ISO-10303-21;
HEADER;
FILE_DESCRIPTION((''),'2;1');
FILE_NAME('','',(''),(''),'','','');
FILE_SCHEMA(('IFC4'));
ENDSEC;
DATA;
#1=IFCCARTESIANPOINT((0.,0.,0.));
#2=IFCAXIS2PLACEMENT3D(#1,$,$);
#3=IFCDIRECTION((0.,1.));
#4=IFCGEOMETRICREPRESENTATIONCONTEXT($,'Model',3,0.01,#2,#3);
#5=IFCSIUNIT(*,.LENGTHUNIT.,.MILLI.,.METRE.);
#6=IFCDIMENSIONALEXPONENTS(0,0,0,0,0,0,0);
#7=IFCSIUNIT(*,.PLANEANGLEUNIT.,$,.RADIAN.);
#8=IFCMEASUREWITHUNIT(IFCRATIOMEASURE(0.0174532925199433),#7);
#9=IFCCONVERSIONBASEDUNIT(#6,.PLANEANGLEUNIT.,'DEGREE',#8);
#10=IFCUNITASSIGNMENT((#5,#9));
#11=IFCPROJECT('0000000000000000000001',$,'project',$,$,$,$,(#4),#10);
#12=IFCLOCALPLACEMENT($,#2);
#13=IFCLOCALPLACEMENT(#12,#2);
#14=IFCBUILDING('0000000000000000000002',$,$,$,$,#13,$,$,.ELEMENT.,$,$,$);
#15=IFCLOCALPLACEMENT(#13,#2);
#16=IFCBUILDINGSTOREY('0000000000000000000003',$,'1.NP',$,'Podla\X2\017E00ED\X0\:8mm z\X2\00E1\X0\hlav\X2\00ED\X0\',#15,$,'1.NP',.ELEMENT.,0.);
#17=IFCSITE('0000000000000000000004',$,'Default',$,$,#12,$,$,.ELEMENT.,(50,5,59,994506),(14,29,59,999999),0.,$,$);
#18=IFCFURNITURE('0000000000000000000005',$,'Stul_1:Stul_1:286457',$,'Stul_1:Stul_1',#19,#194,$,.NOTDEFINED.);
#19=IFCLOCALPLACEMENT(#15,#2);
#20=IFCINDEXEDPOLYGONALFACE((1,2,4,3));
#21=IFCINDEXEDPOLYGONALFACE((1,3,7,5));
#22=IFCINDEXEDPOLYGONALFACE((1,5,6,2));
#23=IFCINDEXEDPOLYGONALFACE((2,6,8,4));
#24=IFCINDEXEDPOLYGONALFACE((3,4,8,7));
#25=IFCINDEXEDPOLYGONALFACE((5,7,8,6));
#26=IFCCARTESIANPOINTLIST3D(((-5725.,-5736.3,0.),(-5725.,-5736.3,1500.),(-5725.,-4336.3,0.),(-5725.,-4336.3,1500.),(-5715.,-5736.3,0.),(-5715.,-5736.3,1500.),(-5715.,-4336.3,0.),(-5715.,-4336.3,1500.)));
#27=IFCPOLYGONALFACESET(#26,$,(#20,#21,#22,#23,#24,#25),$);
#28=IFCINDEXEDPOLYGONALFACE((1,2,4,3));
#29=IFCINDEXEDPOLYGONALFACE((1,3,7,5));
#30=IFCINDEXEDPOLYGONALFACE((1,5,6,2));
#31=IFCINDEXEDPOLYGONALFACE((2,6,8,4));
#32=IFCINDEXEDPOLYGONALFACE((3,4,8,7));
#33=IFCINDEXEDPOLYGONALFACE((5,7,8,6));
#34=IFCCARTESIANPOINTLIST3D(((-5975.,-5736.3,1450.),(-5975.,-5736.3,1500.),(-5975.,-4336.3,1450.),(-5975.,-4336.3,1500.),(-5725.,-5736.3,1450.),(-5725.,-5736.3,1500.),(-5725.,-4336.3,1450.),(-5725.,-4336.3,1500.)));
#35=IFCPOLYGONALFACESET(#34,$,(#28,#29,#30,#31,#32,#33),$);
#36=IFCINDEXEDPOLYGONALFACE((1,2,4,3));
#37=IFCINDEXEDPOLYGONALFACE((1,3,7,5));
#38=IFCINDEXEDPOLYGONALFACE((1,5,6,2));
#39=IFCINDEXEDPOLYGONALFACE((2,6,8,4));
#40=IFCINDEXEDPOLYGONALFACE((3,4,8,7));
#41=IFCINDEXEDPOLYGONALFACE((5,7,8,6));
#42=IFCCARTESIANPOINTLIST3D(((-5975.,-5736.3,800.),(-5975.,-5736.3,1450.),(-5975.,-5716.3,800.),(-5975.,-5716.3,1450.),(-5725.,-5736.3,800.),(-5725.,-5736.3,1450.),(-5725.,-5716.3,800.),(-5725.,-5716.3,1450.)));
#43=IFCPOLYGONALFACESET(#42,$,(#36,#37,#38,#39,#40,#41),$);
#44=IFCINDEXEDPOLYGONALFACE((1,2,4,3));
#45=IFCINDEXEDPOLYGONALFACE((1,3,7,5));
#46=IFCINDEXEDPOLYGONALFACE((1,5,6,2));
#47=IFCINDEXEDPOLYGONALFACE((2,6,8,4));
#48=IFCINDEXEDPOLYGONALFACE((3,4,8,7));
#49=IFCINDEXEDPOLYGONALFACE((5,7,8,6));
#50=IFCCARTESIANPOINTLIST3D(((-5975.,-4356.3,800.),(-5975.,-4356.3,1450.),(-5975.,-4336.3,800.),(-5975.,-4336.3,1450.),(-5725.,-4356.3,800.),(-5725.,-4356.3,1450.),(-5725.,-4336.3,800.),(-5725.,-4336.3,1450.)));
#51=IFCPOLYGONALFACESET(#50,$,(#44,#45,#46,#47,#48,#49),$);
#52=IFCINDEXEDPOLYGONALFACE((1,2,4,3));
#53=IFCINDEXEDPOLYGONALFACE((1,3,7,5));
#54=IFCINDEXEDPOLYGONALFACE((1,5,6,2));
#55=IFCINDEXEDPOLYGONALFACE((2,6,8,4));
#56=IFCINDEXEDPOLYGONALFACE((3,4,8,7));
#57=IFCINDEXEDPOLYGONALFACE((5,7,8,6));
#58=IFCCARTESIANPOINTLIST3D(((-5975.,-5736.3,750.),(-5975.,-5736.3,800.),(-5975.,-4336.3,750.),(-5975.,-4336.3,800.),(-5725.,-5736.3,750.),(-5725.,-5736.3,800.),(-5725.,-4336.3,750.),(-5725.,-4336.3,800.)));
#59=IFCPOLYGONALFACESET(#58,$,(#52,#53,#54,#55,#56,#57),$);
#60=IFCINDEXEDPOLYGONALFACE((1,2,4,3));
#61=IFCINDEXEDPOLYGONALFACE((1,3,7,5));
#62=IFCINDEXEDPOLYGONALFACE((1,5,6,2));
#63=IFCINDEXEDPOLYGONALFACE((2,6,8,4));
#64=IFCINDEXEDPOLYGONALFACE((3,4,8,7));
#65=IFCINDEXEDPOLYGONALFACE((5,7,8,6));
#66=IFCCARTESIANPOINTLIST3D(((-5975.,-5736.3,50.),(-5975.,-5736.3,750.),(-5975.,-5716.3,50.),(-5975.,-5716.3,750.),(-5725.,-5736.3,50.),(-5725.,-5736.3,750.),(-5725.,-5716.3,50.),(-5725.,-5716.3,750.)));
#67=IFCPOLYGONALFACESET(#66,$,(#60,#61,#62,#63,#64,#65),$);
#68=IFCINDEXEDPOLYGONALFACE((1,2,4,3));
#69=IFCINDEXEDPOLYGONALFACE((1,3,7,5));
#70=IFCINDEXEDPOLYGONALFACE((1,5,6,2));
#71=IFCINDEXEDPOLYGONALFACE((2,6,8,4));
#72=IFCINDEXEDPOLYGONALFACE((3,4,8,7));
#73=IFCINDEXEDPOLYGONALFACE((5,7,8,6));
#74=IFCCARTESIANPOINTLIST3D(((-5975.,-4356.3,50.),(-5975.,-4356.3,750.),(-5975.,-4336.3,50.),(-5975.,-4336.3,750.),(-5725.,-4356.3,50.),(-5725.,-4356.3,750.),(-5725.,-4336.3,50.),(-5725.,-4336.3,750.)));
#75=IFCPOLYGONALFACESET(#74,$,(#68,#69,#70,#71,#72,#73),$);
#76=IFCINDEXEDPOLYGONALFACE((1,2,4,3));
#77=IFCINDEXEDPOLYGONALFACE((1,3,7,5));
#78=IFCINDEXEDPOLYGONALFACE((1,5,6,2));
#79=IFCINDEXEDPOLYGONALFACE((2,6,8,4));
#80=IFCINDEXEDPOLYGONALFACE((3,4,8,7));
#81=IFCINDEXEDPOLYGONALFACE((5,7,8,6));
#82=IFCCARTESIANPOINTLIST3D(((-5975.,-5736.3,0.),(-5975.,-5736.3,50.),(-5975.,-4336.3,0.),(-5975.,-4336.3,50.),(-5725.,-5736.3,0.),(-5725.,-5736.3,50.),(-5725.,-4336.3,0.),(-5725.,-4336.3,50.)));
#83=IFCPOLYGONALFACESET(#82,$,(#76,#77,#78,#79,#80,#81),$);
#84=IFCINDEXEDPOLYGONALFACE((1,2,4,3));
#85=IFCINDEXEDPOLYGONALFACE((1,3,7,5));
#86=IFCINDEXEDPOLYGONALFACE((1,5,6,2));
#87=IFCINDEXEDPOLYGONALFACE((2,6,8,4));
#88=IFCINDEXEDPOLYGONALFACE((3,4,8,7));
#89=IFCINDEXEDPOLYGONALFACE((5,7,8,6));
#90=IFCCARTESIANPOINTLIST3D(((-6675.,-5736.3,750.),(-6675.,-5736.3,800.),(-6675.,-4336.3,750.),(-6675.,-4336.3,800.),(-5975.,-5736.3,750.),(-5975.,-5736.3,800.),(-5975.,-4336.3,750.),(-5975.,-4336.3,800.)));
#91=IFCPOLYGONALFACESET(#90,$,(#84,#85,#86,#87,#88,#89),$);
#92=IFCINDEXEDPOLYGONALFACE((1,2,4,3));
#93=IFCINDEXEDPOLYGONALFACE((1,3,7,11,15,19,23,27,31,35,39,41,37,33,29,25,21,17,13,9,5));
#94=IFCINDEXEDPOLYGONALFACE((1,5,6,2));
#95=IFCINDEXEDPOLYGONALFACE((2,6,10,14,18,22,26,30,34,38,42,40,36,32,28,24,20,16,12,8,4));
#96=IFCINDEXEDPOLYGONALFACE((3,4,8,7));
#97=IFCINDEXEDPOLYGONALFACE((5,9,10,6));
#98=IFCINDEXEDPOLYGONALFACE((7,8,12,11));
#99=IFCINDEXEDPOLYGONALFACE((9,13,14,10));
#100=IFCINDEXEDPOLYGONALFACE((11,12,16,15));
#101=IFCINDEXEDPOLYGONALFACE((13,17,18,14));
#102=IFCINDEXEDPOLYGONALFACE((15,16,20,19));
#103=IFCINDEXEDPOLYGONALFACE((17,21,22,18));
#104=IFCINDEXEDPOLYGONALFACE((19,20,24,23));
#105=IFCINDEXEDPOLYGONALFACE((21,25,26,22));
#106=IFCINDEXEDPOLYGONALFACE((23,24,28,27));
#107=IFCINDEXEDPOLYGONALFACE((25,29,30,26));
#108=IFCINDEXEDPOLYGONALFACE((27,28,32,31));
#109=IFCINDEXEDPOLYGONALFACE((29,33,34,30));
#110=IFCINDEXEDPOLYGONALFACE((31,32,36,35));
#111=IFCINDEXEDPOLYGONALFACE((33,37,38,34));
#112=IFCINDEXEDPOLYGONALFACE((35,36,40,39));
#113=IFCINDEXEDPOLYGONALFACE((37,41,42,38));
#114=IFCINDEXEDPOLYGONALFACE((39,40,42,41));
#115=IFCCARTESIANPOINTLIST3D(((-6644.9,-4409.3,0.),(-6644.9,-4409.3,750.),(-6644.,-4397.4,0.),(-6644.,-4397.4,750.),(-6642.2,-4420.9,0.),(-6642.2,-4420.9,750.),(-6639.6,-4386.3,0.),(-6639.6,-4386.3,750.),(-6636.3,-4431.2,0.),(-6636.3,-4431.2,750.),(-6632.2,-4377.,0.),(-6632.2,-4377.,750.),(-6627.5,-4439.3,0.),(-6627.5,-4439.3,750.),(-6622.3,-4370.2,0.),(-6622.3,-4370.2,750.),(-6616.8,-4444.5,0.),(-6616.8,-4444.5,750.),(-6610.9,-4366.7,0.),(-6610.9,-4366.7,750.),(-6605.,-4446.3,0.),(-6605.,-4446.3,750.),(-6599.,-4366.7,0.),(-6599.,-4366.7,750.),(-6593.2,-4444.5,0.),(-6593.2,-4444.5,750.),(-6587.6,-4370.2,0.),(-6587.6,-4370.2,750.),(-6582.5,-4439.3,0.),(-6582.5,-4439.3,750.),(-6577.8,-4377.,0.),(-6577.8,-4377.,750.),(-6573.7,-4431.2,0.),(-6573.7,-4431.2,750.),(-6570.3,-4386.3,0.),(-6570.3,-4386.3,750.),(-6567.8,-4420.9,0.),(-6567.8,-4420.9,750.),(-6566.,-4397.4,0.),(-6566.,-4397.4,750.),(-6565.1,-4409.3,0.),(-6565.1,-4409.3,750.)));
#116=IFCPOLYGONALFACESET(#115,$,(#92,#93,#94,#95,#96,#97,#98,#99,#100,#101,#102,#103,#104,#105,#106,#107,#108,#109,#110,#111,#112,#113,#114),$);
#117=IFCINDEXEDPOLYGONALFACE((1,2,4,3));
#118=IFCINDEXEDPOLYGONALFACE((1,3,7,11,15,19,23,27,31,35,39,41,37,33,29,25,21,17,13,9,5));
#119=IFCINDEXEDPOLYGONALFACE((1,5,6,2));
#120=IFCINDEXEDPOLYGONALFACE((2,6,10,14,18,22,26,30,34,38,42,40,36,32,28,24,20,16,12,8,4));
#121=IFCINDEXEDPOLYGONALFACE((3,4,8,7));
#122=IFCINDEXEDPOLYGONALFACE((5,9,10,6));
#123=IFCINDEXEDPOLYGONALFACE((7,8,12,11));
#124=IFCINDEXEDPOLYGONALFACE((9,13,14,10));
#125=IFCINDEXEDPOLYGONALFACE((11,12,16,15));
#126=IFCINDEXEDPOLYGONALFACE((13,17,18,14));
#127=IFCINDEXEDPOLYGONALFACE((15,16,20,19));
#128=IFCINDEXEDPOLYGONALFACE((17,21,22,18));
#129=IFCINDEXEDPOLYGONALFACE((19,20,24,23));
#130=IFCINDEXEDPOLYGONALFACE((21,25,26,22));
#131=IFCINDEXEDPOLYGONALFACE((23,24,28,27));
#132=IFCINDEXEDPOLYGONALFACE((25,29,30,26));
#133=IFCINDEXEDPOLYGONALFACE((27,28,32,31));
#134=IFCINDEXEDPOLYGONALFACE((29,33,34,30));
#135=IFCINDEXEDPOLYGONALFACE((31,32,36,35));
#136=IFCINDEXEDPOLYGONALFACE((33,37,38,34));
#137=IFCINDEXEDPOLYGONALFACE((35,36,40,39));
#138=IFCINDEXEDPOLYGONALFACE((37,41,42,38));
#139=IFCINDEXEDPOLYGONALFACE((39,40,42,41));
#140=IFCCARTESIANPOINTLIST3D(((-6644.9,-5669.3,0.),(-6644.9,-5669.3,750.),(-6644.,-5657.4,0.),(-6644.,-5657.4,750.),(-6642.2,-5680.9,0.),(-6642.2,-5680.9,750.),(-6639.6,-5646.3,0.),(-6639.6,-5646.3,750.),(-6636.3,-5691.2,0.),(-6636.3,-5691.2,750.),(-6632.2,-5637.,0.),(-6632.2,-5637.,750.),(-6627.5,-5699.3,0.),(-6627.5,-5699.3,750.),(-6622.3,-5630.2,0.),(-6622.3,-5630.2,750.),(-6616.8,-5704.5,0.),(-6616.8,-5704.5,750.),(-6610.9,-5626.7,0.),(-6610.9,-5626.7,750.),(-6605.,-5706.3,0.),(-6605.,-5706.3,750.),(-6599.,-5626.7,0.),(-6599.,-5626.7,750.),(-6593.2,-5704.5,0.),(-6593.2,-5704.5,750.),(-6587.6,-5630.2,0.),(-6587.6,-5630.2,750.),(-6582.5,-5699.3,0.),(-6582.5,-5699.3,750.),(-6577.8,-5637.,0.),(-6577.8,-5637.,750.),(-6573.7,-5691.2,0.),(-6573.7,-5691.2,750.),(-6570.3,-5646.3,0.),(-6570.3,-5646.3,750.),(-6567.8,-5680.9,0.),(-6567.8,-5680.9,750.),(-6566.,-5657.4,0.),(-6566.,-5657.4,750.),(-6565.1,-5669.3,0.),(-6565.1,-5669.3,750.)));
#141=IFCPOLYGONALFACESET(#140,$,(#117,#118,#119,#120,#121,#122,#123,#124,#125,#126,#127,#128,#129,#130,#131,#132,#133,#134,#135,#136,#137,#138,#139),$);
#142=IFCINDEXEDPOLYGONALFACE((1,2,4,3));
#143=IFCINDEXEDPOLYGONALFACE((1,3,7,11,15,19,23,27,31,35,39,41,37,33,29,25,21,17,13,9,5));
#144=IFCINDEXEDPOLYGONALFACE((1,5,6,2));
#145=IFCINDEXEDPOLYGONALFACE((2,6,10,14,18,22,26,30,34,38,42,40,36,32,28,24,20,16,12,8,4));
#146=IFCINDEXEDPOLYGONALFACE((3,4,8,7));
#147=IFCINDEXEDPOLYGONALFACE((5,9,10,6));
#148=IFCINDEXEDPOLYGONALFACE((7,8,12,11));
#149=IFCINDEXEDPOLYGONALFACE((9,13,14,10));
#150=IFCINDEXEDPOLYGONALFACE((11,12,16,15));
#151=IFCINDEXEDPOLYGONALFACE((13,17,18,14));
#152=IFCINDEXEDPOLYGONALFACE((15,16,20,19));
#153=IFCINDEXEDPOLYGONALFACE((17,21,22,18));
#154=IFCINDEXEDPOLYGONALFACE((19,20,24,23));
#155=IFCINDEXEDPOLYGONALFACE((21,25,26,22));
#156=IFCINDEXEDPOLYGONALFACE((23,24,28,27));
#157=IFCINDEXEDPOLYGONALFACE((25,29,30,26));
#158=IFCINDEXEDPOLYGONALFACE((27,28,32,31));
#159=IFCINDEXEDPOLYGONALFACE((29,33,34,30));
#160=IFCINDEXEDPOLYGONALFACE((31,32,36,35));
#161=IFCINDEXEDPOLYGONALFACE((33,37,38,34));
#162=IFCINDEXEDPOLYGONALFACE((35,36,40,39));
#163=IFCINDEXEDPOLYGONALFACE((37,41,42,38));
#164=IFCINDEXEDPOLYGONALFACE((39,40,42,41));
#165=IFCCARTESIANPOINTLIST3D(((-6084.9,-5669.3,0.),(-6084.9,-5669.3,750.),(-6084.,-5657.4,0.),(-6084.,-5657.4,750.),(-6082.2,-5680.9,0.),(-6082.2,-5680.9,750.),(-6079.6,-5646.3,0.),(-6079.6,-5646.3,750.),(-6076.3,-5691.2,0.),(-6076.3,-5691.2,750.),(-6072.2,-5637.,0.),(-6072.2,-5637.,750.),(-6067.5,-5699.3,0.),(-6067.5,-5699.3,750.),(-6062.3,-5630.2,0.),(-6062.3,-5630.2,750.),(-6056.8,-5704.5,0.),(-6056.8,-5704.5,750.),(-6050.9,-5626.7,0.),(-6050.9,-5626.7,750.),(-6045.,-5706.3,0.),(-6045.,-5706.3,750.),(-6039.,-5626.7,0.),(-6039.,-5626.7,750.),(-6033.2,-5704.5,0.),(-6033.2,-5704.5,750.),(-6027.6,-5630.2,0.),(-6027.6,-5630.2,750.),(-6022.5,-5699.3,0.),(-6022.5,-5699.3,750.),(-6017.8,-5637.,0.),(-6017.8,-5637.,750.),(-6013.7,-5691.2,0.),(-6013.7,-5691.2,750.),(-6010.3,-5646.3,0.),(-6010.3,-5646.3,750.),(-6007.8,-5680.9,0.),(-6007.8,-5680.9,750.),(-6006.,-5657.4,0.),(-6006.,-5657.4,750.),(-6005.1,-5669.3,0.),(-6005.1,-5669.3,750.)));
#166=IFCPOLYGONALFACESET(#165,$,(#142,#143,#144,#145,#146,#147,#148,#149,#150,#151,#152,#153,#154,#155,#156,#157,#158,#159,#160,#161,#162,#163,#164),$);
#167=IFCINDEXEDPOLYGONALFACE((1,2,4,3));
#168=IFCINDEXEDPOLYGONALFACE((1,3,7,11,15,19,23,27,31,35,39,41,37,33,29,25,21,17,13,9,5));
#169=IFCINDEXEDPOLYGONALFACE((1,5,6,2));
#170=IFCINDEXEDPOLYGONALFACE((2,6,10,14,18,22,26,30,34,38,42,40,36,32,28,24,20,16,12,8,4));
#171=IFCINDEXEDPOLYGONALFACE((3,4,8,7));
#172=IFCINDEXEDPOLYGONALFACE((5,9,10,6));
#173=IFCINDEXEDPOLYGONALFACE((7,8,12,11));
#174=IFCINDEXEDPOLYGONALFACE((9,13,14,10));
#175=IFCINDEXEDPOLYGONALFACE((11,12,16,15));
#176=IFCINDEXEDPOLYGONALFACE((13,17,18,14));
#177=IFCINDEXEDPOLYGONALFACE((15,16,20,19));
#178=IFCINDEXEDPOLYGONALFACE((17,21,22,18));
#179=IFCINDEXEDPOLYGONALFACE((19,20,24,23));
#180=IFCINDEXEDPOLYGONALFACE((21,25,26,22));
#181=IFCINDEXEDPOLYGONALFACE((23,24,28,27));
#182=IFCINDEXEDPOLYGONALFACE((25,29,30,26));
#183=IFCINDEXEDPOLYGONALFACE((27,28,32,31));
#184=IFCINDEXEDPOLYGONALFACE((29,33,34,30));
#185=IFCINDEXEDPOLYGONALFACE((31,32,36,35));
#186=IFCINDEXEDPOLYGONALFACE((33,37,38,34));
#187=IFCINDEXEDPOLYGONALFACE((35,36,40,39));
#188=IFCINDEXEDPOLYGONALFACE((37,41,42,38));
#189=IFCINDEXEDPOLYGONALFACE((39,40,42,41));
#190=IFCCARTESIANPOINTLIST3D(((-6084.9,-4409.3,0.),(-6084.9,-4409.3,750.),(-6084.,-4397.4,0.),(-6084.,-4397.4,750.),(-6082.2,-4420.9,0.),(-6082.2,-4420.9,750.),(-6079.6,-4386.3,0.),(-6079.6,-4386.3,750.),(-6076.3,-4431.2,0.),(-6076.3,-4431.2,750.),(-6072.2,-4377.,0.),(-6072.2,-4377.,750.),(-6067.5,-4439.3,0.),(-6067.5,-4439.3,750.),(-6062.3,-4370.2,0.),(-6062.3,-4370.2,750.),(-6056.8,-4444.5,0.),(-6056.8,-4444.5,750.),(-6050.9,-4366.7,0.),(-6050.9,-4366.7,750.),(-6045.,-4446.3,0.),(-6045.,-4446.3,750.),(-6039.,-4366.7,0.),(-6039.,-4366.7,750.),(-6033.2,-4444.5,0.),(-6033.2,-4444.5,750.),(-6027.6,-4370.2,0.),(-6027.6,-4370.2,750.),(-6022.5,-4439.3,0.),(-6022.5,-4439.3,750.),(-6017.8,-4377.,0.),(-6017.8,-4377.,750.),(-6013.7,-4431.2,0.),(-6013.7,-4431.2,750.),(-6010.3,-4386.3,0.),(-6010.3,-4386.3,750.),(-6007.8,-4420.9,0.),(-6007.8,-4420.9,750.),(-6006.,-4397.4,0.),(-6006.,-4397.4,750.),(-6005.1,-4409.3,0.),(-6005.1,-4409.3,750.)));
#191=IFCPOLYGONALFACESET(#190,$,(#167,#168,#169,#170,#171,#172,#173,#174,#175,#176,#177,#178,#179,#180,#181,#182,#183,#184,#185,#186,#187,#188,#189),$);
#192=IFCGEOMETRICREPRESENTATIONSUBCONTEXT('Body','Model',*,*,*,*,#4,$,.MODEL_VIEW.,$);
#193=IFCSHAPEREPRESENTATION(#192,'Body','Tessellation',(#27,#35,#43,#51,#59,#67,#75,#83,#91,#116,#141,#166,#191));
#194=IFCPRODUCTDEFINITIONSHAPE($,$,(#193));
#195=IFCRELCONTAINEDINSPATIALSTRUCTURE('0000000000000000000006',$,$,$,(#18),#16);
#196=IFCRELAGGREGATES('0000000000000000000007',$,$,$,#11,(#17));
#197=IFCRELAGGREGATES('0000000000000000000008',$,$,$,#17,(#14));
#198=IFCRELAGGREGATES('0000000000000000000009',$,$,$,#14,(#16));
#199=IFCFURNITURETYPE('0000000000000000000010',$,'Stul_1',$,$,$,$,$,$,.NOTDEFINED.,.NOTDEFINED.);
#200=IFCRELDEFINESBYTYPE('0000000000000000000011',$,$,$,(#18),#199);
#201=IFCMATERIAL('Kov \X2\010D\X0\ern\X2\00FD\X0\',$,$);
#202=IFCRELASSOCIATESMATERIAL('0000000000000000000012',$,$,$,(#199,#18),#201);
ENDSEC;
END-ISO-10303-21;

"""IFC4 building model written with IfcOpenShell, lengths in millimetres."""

from ifc_helpers import new_model, entity, si_unit, converted_unit, direction, frame, frame_2d, origin, origin_2d_with_axis, place, context, subcontext, project, spatial, rectangle, circle, extrude, source, transform, mapped, material, type_object, type_shapes, element, save


model = new_model("IFC4")

# Units and contexts
model_context = context("Model", 3, precision=0.01, world=origin(), true_north=direction((0.0, 1.0)))
body_context = subcontext(model_context, "Body", "Model", "MODEL_VIEW")
ifc_project = project(units=[si_unit("LENGTHUNIT", "METRE", prefix="MILLI"), converted_unit("PLANEANGLEUNIT", "DEGREE", entity("IfcRatioMeasure", 0.0174532925199433), si_unit("PLANEANGLEUNIT", "RADIAN"), dimensions=[0, 0, 0, 0, 0, 0, 0])], contexts=[model_context])

# Site, building, storey
site_placement = place(None, origin())
site = spatial("IfcSite", under=ifc_project, at=site_placement, Name="Default", CompositionType="ELEMENT", RefLatitude=(50, 5, 59, 994506), RefLongitude=(14, 29, 59, 999999), RefElevation=0.0)
building_placement = place(site_placement, origin())
building = spatial("IfcBuilding", under=site, at=building_placement, CompositionType="ELEMENT")
storey_placement = place(building_placement, origin())
storey = spatial("IfcBuildingStorey", under=building, at=storey_placement, Name="1.NP", ObjectType="Podlaží:8mm záhlaví", LongName="1.NP", CompositionType="ELEMENT", Elevation=0.0)

# Furniture
ifc_material_1 = material(Name="Kov černý")
furniture_type = type_object("IfcFurnitureType", Name="Stul_1", AssemblyPlace="NOTDEFINED", PredefinedType="NOTDEFINED", material=ifc_material_1)
shared_shape_1 = source(origin(), body_context, "Body", "SweptSolid", [
    extrude(rectangle(XDim=1400.0, YDim=10.0, at=origin_2d_with_axis()), frame((0.0, 605.0, 0.0), z_axis=(0.0, 0.0, 1.0), x_axis=(-1.0, 0.0, 0.0)), (0.0, 0.0, 1.0), 1500.0),
    extrude(rectangle(XDim=1400.0, YDim=250.0, at=frame_2d((0.0, 0.0), x_axis=(1.0, 0.0))), frame((0.0, 475.0, 1450.0), z_axis=(0.0, 0.0, 1.0), x_axis=(-1.0, 0.0, 0.0)), (0.0, 0.0, 1.0), 50.0),
    extrude(rectangle(XDim=20.0, YDim=250.0, at=origin_2d_with_axis()), frame((690.0, 475.0, 800.0), z_axis=(0.0, 0.0, 1.0), x_axis=(-1.0, 0.0, 0.0)), (0.0, 0.0, 1.0), 650.0),
    extrude(rectangle(XDim=20.0, YDim=250.0, at=frame_2d((0.0, 0.0), x_axis=(1.0, 0.0))), frame((-690.0, 475.0, 800.0), z_axis=(0.0, 0.0, 1.0), x_axis=(-1.0, 0.0, 0.0)), (0.0, 0.0, 1.0), 650.0),
    extrude(rectangle(XDim=1400.0, YDim=250.0, at=origin_2d_with_axis()), frame((0.0, 475.0, 750.0), z_axis=(0.0, 0.0, 1.0), x_axis=(-1.0, 0.0, 0.0)), (0.0, 0.0, 1.0), 50.0),
    extrude(rectangle(XDim=20.0, YDim=250.0, at=origin_2d_with_axis()), frame((690.0, 475.0, 50.0), z_axis=(0.0, 0.0, 1.0), x_axis=(-1.0, 0.0, 0.0)), (0.0, 0.0, 1.0), 700.0),
    extrude(rectangle(XDim=20.0, YDim=250.0, at=frame_2d((0.0, 0.0), x_axis=(1.0, 0.0))), frame((-690.0, 475.0, 50.0), z_axis=(0.0, 0.0, 1.0), x_axis=(-1.0, 0.0, 0.0)), (0.0, 0.0, 1.0), 700.0),
    extrude(rectangle(XDim=1400.0, YDim=250.0, at=origin_2d_with_axis()), frame((0.0, 475.0, 0.0), z_axis=(0.0, 0.0, 1.0), x_axis=(-1.0, 0.0, 0.0)), (0.0, 0.0, 1.0), 50.0),
    extrude(rectangle(XDim=1400.0, YDim=700.0, at=origin_2d_with_axis()), frame((0.0, 0.0, 750.0), z_axis=(0.0, 0.0, 1.0), x_axis=(-1.0, 0.0, 0.0)), (0.0, 0.0, 1.0), 50.0),
    extrude(circle(Radius=40.0, at=frame_2d((0.0, 0.0), x_axis=(1.0, 0.0))), frame((-630.0, -280.0, 0.0)), (0.0, 0.0, 1.0), 750.0),
    extrude(circle(Radius=40.0, at=frame_2d((0.0, 0.0), x_axis=(1.0, 0.0))), frame((630.0, -280.0, 0.0)), (0.0, 0.0, 1.0), 750.0),
    extrude(circle(Radius=40.0, at=frame_2d((0.0, 0.0), x_axis=(1.0, 0.0))), frame((630.0, 280.0, 0.0)), (0.0, 0.0, 1.0), 750.0),
    extrude(circle(Radius=40.0, at=frame_2d((0.0, 0.0), x_axis=(1.0, 0.0))), frame((-630.0, 280.0, 0.0)), (0.0, 0.0, 1.0), 750.0),
])
type_shapes(furniture_type, [shared_shape_1])
for number, where, z_axis, x_axis, name in (
    (1, (-6325.0, -5036.3, 0.0), (0.0, 0.0, 1.0), (0.0, -1.0, 0.0), "Stul_1:Stul_1:286457"),
):
    element("IfcFurniture", number, at=place(storey_placement, frame(where, z_axis=z_axis, x_axis=x_axis)), inside=storey, type_object=furniture_type, material=ifc_material_1, Name=name, ObjectType="Stul_1:Stul_1", PredefinedType="NOTDEFINED", context=body_context, shape_type="MappedRepresentation", body=[
        mapped(shared_shape_1, transform((0.0, 0.0, 0.0), scale=1.0)),
    ])

save(model, "model.ifc")
